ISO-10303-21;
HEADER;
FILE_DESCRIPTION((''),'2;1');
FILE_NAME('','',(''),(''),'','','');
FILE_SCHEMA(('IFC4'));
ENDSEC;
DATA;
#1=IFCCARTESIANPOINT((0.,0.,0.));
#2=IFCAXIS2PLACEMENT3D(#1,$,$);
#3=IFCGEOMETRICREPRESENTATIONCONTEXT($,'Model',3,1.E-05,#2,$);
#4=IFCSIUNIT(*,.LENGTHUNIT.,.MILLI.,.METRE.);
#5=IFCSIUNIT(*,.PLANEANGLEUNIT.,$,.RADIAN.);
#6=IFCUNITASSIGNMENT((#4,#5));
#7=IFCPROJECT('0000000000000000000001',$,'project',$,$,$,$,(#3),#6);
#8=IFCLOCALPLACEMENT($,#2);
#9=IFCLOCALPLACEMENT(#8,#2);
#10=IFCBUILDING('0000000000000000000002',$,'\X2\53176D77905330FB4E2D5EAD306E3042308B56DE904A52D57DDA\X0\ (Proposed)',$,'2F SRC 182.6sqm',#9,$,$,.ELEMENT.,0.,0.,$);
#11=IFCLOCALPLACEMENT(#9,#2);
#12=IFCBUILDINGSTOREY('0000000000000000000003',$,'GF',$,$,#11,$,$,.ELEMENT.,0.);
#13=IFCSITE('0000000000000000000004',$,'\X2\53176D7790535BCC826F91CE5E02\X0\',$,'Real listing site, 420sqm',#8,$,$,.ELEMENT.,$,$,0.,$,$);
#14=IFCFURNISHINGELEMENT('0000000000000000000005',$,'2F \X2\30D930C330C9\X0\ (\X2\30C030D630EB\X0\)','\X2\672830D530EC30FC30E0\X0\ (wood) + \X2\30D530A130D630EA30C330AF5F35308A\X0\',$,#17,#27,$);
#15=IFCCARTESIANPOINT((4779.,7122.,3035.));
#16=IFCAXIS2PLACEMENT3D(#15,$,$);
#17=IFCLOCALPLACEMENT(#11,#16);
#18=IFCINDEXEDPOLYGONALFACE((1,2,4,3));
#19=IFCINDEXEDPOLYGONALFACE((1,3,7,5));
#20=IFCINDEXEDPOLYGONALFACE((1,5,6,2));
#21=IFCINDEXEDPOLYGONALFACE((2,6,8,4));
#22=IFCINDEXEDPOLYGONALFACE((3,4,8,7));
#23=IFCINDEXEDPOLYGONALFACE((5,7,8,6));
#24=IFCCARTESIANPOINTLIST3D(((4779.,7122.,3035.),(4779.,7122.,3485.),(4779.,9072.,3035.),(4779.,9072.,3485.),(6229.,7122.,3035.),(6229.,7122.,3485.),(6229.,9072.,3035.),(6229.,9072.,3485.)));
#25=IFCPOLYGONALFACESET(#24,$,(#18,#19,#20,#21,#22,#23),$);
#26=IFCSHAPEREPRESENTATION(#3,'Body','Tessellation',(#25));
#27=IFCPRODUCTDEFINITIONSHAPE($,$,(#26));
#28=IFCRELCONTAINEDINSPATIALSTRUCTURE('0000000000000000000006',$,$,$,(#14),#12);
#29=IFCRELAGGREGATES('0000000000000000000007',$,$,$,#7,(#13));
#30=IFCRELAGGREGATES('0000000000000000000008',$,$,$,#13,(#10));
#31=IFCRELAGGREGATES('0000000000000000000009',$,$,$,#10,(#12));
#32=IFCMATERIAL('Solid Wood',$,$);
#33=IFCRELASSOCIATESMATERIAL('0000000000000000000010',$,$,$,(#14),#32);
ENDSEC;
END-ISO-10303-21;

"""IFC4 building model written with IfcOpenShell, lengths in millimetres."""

from ifc_helpers import new_model, si_unit, frame, frame_2d, origin, place, context, project, spatial, rectangle, extrude, material, element, save


model = new_model("IFC4")

# Units and contexts
model_context = context("Model", 3, precision=1e-05, world=origin())
ifc_project = project(units=[si_unit("LENGTHUNIT", "METRE", prefix="MILLI"), si_unit("PLANEANGLEUNIT", "RADIAN")], contexts=[model_context])

# Site, building, storey
site_placement = place(None, origin())
site = spatial("IfcSite", under=ifc_project, at=site_placement, Name="北海道富良野市", ObjectType="Real listing site, 420sqm", CompositionType="ELEMENT", RefElevation=0.0)
building_placement = place(site_placement, origin())
building = spatial("IfcBuilding", under=site, at=building_placement, Name="北海道・中庭のある回遊動線 (Proposed)", ObjectType="2F SRC 182.6sqm", CompositionType="ELEMENT", ElevationOfRefHeight=0.0, ElevationOfTerrain=0.0)
storey_placement = place(building_placement, origin())
storey = spatial("IfcBuildingStorey", under=building, at=storey_placement, Name="GF", CompositionType="ELEMENT", Elevation=0.0)

# Shared definitions
ifc_material_1 = material(Name="Solid Wood")

# Furnishing element
furnishing_1_placement = place(storey_placement, frame((4779.0, 7122.0, 3035.0)))
element("IfcFurnishingElement", 1, at=furnishing_1_placement, inside=storey, material=ifc_material_1, Name="2F ベッド (ダブル)", Description="木フレーム (wood) + ファブリック張り", context=model_context, shape_type="SweptSolid", body=[
    extrude(rectangle(XDim=1450.0, YDim=1950.0, at=frame_2d((725.0, 975.0))), frame((4779.0, 7122.0, 3035.0)), (0.0, 0.0, 1.0), 450.0),
])

save(model, "model.ifc")
